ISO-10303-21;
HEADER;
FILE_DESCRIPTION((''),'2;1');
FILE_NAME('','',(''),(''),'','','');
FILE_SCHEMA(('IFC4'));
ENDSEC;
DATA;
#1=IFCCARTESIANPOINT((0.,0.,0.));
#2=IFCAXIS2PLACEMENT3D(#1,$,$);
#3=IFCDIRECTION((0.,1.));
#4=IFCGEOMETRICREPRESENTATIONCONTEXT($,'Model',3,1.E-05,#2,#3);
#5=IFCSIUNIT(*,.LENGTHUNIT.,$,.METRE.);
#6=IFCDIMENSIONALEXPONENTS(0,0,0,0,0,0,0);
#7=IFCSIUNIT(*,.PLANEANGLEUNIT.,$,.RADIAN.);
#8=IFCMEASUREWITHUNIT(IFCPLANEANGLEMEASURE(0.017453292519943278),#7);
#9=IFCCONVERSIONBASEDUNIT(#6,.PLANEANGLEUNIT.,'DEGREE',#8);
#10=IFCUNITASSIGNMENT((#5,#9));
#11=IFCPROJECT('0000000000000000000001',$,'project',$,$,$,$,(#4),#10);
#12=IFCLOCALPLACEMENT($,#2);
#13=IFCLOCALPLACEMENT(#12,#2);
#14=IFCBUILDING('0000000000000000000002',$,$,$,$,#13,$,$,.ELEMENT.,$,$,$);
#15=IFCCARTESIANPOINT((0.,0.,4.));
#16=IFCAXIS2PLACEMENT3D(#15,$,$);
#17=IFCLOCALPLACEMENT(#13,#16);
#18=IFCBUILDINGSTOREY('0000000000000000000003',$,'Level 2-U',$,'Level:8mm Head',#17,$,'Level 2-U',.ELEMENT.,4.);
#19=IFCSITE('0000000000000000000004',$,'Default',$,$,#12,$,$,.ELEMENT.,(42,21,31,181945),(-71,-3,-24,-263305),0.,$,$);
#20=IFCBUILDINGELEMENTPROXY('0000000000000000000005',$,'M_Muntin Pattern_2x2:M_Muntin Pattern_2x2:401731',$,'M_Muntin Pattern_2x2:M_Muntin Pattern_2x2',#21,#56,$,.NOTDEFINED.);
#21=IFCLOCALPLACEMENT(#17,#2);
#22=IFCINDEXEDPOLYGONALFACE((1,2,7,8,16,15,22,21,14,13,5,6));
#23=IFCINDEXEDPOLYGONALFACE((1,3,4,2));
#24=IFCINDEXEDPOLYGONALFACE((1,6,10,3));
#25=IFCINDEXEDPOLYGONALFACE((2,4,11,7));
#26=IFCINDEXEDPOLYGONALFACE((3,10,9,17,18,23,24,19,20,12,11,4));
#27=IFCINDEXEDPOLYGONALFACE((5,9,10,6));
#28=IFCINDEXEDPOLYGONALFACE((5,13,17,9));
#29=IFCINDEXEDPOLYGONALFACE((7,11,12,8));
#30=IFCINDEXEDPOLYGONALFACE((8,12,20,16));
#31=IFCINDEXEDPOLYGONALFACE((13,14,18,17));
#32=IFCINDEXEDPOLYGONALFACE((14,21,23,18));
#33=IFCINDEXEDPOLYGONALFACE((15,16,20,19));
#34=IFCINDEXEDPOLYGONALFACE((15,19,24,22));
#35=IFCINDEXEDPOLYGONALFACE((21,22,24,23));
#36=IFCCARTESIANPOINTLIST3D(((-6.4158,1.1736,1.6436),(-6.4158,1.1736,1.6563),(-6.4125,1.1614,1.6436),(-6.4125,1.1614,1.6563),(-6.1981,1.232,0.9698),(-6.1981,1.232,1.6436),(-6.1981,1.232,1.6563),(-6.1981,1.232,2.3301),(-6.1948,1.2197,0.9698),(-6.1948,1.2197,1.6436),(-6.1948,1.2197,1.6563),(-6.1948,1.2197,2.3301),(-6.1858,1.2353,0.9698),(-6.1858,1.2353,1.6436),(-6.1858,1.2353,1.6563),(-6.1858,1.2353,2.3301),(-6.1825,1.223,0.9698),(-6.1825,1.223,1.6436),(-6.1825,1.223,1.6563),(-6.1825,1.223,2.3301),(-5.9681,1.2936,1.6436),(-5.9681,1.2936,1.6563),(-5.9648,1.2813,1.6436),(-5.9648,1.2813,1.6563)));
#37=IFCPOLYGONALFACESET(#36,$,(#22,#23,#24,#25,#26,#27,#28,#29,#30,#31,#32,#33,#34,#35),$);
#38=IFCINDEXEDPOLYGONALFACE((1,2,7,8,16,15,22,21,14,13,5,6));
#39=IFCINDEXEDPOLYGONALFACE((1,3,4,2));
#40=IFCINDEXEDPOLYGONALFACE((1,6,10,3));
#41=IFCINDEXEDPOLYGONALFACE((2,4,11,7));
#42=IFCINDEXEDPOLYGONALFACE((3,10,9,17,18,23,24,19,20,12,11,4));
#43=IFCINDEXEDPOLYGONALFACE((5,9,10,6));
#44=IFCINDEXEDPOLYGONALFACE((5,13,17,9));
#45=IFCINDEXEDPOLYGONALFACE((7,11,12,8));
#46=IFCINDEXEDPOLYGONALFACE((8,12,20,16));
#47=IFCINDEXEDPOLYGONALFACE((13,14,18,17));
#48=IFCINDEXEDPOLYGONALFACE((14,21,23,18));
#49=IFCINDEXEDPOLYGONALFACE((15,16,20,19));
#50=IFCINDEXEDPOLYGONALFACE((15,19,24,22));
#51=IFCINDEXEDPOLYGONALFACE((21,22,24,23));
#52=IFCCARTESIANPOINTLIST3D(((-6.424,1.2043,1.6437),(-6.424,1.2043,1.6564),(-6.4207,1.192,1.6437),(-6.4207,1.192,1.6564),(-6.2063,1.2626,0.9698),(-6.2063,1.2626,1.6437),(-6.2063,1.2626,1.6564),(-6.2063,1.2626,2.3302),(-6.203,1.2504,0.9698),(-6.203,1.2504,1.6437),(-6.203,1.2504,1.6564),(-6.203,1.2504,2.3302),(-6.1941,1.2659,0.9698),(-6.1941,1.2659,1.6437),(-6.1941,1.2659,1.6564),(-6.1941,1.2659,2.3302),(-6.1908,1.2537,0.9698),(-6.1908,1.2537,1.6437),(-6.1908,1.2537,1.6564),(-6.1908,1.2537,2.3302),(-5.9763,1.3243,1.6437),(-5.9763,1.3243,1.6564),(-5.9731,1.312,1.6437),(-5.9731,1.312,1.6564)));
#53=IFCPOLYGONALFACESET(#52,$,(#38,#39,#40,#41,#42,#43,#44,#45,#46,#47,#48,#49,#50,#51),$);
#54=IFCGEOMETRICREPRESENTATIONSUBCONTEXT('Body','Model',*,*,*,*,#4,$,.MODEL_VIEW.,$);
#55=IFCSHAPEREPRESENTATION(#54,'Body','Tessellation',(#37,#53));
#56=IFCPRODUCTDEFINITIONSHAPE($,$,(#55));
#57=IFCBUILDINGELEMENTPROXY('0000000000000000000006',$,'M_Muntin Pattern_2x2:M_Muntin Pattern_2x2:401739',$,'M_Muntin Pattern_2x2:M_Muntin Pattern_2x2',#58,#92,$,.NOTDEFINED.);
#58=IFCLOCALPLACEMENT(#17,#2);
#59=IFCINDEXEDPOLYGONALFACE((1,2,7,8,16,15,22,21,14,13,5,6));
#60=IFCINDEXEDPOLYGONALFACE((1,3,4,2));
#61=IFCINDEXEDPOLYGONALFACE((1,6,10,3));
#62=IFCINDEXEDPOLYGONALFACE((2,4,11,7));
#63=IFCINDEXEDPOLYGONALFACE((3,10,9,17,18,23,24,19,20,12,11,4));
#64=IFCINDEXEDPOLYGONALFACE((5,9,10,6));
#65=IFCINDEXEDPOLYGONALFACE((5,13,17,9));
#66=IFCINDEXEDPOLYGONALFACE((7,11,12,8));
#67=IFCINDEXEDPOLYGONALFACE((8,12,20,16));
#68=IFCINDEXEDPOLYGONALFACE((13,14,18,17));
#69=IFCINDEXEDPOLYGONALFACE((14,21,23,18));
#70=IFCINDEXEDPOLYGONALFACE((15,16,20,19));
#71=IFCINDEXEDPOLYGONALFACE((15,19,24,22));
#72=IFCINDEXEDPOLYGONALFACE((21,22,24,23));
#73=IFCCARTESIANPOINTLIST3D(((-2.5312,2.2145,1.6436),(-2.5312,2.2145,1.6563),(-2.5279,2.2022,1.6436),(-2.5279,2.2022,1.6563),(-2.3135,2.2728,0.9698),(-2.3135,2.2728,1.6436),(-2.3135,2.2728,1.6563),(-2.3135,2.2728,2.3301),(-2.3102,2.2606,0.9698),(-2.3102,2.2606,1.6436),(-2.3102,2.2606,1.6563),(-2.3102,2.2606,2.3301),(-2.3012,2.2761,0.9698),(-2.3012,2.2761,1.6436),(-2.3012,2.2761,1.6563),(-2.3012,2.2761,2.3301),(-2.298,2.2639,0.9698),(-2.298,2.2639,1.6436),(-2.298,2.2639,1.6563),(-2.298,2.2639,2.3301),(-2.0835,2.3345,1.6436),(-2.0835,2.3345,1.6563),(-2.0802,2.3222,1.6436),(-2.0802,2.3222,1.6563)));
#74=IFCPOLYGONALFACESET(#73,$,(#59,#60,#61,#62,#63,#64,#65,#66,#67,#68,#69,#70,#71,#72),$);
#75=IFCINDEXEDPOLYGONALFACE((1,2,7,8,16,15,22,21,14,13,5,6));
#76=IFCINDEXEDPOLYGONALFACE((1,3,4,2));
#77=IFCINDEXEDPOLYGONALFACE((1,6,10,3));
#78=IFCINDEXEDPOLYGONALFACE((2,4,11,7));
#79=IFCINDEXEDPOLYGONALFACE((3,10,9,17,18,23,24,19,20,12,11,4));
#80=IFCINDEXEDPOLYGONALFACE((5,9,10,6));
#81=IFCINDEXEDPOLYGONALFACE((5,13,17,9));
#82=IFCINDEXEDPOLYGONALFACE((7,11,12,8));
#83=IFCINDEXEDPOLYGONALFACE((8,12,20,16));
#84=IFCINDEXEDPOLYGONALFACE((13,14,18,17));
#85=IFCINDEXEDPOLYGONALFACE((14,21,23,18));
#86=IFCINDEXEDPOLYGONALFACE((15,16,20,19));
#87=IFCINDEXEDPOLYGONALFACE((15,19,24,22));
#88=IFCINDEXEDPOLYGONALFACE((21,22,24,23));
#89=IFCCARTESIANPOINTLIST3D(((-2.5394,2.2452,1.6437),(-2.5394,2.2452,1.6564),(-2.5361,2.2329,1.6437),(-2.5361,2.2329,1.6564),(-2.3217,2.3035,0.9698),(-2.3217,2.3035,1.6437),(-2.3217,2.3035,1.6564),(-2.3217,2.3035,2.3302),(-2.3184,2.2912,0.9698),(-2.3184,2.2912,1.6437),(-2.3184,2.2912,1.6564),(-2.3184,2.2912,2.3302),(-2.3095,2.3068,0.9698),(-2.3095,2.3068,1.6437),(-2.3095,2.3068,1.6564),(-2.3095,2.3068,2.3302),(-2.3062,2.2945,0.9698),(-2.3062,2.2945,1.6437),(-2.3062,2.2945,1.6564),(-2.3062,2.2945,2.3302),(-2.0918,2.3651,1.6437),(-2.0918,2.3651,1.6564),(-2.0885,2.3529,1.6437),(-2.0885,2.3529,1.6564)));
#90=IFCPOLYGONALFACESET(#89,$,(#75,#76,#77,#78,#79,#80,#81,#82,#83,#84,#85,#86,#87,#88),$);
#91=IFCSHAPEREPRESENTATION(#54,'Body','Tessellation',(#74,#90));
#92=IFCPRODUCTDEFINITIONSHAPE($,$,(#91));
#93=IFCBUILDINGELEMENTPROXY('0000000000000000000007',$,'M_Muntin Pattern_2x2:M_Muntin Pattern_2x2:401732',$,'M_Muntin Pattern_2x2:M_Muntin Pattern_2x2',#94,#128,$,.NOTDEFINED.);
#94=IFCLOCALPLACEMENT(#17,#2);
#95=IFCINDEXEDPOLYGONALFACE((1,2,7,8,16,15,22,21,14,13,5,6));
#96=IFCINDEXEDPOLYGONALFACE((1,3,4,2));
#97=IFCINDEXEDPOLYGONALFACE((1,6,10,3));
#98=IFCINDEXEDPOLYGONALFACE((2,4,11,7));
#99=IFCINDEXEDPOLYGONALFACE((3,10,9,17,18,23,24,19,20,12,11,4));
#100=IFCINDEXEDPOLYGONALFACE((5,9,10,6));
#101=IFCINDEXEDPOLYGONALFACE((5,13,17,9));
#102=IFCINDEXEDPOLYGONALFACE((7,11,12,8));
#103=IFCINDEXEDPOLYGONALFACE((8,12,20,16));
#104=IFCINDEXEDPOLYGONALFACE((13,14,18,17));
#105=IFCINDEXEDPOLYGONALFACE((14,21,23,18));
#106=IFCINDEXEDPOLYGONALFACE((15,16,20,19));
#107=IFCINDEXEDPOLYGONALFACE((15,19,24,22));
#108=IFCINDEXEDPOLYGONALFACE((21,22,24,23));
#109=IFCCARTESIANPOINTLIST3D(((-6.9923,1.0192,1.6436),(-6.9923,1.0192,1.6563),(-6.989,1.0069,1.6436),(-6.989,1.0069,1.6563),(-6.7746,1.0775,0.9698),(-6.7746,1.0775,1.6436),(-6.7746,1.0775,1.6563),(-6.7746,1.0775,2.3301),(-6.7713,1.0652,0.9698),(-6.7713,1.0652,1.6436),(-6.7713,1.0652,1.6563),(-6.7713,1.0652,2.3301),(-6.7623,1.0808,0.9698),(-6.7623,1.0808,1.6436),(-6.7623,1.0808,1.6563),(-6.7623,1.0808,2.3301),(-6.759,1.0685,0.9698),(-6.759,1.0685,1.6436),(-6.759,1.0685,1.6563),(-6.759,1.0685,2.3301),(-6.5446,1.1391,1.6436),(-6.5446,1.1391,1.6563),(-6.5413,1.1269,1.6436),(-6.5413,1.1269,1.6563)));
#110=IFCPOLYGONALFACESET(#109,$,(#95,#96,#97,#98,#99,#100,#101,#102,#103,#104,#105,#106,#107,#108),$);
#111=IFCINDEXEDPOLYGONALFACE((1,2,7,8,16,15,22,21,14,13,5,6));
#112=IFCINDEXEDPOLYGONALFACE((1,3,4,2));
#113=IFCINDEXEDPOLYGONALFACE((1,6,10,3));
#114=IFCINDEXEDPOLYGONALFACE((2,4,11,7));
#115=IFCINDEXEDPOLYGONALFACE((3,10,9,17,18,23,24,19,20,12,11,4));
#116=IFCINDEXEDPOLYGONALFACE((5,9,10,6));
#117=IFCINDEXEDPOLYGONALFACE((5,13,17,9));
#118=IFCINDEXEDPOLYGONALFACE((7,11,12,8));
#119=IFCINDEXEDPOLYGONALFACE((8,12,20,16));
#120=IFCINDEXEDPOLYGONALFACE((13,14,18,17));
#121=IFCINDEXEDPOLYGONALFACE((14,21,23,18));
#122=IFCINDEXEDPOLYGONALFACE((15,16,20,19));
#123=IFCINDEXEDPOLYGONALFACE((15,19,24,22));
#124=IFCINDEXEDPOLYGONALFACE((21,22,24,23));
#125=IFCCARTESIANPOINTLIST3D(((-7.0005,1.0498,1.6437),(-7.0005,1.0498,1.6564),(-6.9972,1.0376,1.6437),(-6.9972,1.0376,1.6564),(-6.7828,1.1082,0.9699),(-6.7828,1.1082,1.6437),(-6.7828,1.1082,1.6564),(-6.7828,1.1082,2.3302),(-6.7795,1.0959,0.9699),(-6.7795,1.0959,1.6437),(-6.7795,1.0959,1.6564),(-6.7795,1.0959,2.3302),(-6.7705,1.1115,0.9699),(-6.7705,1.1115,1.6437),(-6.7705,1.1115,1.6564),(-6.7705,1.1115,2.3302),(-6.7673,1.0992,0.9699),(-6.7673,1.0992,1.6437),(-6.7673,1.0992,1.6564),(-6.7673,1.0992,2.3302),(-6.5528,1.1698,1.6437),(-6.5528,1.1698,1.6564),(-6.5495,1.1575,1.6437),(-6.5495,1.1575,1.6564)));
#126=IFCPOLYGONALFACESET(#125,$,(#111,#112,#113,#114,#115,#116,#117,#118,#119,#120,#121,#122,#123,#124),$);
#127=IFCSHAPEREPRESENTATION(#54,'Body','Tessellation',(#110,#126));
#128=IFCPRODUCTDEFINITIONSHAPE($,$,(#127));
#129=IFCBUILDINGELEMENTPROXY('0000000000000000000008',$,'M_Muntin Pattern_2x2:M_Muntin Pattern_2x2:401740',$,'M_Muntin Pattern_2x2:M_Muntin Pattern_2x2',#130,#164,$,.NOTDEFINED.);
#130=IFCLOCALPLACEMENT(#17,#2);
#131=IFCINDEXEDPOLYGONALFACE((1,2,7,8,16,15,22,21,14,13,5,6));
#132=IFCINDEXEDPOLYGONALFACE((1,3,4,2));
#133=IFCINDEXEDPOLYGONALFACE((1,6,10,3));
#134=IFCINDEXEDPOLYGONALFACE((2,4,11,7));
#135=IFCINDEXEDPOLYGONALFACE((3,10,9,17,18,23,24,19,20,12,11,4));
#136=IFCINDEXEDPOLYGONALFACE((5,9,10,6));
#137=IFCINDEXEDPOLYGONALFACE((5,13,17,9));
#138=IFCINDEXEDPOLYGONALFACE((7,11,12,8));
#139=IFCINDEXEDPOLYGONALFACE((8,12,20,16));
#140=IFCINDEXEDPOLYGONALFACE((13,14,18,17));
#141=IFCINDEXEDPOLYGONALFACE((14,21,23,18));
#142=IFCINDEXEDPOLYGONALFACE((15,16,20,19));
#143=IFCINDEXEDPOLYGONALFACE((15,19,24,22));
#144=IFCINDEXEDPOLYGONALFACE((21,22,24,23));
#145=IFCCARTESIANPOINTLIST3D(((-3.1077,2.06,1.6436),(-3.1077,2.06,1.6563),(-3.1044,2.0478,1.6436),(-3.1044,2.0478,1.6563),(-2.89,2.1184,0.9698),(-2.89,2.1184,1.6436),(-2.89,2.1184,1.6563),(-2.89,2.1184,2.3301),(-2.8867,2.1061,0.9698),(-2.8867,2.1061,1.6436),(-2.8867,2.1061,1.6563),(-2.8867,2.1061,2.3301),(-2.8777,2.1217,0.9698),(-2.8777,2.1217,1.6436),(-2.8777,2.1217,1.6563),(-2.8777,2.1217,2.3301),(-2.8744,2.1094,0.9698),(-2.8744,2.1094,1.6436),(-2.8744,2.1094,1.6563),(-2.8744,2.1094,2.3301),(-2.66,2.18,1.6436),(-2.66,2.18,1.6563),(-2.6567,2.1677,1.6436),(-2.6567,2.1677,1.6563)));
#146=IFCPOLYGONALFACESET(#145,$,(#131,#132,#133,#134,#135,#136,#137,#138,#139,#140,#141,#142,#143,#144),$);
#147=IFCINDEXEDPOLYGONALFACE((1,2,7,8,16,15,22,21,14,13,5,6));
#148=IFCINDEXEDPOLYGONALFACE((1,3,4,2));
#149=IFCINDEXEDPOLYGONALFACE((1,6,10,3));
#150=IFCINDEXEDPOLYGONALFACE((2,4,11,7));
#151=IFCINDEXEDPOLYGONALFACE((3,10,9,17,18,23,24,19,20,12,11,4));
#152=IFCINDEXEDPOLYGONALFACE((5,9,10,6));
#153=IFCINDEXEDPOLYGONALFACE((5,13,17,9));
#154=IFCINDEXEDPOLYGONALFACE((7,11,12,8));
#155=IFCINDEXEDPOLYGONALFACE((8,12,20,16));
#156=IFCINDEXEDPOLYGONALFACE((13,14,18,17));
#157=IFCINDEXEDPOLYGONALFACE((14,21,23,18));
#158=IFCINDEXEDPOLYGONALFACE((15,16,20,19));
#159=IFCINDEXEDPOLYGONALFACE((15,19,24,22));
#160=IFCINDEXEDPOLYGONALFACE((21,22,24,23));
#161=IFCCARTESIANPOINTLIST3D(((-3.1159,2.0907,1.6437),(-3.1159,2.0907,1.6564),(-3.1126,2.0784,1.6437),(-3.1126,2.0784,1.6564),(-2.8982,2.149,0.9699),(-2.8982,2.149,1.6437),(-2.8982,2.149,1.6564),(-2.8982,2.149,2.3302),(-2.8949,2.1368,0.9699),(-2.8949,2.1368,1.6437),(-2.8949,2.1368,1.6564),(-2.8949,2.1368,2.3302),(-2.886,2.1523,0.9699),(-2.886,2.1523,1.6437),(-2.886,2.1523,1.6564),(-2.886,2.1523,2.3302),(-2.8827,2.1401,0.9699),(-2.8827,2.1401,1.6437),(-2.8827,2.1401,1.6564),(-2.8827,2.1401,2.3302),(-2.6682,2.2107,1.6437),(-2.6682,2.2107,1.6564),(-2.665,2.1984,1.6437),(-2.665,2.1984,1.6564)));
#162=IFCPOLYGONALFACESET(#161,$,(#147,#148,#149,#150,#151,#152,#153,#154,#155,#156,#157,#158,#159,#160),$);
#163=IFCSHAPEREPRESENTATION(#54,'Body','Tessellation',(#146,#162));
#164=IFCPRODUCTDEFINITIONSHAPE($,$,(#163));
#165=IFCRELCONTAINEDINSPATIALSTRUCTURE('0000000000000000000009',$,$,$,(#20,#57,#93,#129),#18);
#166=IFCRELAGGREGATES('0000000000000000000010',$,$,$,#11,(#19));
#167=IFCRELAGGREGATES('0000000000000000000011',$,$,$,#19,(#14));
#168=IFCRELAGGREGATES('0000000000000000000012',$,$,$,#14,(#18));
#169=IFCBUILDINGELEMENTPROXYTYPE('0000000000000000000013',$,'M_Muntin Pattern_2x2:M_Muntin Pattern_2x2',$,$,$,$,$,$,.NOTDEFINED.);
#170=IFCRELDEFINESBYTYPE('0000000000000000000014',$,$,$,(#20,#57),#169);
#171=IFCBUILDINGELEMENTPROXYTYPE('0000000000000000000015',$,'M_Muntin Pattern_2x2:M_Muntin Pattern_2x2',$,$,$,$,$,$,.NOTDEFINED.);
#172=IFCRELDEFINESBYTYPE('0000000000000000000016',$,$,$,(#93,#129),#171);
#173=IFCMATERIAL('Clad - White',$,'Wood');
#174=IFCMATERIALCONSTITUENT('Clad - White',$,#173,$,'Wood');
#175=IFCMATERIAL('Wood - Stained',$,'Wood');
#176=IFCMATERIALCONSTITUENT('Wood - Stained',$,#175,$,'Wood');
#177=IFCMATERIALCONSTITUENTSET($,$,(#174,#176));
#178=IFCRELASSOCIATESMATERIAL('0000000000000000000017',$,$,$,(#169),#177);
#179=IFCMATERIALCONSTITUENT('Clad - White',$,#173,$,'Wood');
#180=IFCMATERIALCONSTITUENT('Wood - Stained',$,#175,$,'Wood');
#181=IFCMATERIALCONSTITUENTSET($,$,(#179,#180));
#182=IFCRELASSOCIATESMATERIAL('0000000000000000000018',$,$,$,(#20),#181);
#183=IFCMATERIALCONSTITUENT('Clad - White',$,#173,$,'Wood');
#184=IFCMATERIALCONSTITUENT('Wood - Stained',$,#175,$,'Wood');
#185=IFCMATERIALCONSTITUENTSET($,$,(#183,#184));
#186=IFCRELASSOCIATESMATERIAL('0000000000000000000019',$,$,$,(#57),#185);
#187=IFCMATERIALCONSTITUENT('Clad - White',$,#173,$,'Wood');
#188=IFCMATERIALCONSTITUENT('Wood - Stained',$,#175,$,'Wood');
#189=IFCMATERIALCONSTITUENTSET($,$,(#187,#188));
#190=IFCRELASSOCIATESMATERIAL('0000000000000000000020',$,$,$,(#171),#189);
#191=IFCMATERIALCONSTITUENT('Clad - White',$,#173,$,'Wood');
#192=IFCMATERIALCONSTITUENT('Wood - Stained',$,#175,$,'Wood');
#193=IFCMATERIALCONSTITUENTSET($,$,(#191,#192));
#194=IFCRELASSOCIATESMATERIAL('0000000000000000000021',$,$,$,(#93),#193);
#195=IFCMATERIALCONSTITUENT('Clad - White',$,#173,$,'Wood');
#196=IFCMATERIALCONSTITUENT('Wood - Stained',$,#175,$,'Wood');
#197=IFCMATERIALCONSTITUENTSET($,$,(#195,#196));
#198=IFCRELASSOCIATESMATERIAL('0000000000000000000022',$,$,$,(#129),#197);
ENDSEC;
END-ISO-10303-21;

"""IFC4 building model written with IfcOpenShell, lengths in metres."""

from ifc_helpers import new_model, entity, si_unit, converted_unit, direction, frame, origin, place, context, subcontext, project, spatial, indexed_curve, outline, extrude, source, transform, mapped, material, constituent, constituent_set, type_object, type_shapes, element, save


model = new_model("IFC4")

# Units and contexts
model_context = context("Model", 3, precision=1e-05, world=origin(), true_north=direction((0.0, 1.0)))
body_context = subcontext(model_context, "Body", "Model", "MODEL_VIEW")
ifc_project = project(units=[si_unit("LENGTHUNIT", "METRE"), converted_unit("PLANEANGLEUNIT", "DEGREE", entity("IfcPlaneAngleMeasure", 0.017453292519943278), si_unit("PLANEANGLEUNIT", "RADIAN"), dimensions=[0, 0, 0, 0, 0, 0, 0])], contexts=[model_context])

# Site, building, storey
site_placement = place(None, origin())
site = spatial("IfcSite", under=ifc_project, at=site_placement, Name="Default", CompositionType="ELEMENT", RefLatitude=(42, 21, 31, 181945), RefLongitude=(-71, -3, -24, -263305), RefElevation=0.0)
building_placement = place(site_placement, origin())
building = spatial("IfcBuilding", under=site, at=building_placement, CompositionType="ELEMENT")
storey_placement = place(building_placement, frame((0.0, 0.0, 4.0)))
storey = spatial("IfcBuildingStorey", under=building, at=storey_placement, Name="Level 2-U", ObjectType="Level:8mm Head", LongName="Level 2-U", CompositionType="ELEMENT", Elevation=4.0)

# Building element proxies
ifc_material_1 = material(Name="Clad - White", Category="Wood")
ifc_constituent_1 = constituent(ifc_material_1, Name="Clad - White", Category="Wood")
ifc_material_2 = material(Name="Wood - Stained", Category="Wood")
ifc_constituent_2 = constituent(ifc_material_2, Name="Wood - Stained", Category="Wood")
ifc_constituent_set_1 = constituent_set(constituents=[ifc_constituent_1, ifc_constituent_2])
ifc_constituent_3 = constituent(ifc_material_1, Name="Clad - White", Category="Wood")
ifc_constituent_4 = constituent(ifc_material_2, Name="Wood - Stained", Category="Wood")
ifc_constituent_set_2 = constituent_set(constituents=[ifc_constituent_3, ifc_constituent_4])
building_element_proxy_type_1 = type_object("IfcBuildingElementProxyType", Name="M_Muntin Pattern_2x2:M_Muntin Pattern_2x2", PredefinedType="NOTDEFINED", material=ifc_constituent_set_2)
shared_shape_1 = source(origin(), body_context, "Body", "SweptSolid", [
    extrude(outline(indexed_curve([(0.0064, -0.0064), (0.6801, -0.0064), (0.6801, 0.0063), (0.0064, 0.0063), (0.0064, 0.2317), (-0.0063, 0.2317), (-0.0063, 0.0063), (-0.6802, 0.0063), (-0.6802, -0.0064), (-0.0063, -0.0064), (-0.0063, -0.2317), (0.0064, -0.2317), (0.0064, -0.0064)], self_intersect=False)), frame((0.0, 0.0095, 0.6801), z_axis=(0.0, 1.0, 0.0), x_axis=(0.0, 0.0, 1.0)), (0.0, 0.0, 1.0), 0.0127),
    extrude(outline(indexed_curve([(0.0064, -0.0064), (0.6802, -0.0064), (0.6802, 0.0063), (0.0064, 0.0063), (0.0064, 0.2317), (-0.0063, 0.2317), (-0.0063, 0.0063), (-0.6802, 0.0063), (-0.6802, -0.0064), (-0.0063, -0.0064), (-0.0063, -0.2317), (0.0064, -0.2317), (0.0064, -0.0064)], self_intersect=False)), frame((0.0, -0.0222, 0.6802), z_axis=(0.0, 1.0, 0.0), x_axis=(0.0, 0.0, 1.0)), (0.0, 0.0, 1.0), 0.0127),
])
type_shapes(building_element_proxy_type_1, [shared_shape_1])
proxy_1_placement = place(storey_placement, frame((-6.1944, 1.2428, 0.9698), z_axis=(0.0, 0.0, 1.0), x_axis=(-0.965926, -0.258819, 0.0)))
element("IfcBuildingElementProxy", 1, at=proxy_1_placement, inside=storey, type_object=building_element_proxy_type_1, material=ifc_constituent_set_1, Name="M_Muntin Pattern_2x2:M_Muntin Pattern_2x2:401731", ObjectType="M_Muntin Pattern_2x2:M_Muntin Pattern_2x2", PredefinedType="NOTDEFINED", context=body_context, shape_type="MappedRepresentation", body=[
    mapped(shared_shape_1, transform((0.0, 0.0, 0.0), scale=1.0)),
])
ifc_constituent_5 = constituent(ifc_material_1, Name="Clad - White", Category="Wood")
ifc_constituent_6 = constituent(ifc_material_2, Name="Wood - Stained", Category="Wood")
ifc_constituent_set_3 = constituent_set(constituents=[ifc_constituent_5, ifc_constituent_6])
proxy_2_placement = place(storey_placement, frame((-2.3098, 2.2837, 0.9698), z_axis=(0.0, 0.0, 1.0), x_axis=(-0.965926, -0.258819, 0.0)))
element("IfcBuildingElementProxy", 2, at=proxy_2_placement, inside=storey, type_object=building_element_proxy_type_1, material=ifc_constituent_set_3, Name="M_Muntin Pattern_2x2:M_Muntin Pattern_2x2:401739", ObjectType="M_Muntin Pattern_2x2:M_Muntin Pattern_2x2", PredefinedType="NOTDEFINED", context=body_context, shape_type="MappedRepresentation", body=[
    mapped(shared_shape_1, transform((0.0, 0.0, 0.0), scale=1.0)),
])
ifc_constituent_7 = constituent(ifc_material_1, Name="Clad - White", Category="Wood")
ifc_constituent_8 = constituent(ifc_material_2, Name="Wood - Stained", Category="Wood")
ifc_constituent_set_4 = constituent_set(constituents=[ifc_constituent_7, ifc_constituent_8])
ifc_constituent_9 = constituent(ifc_material_1, Name="Clad - White", Category="Wood")
ifc_constituent_10 = constituent(ifc_material_2, Name="Wood - Stained", Category="Wood")
ifc_constituent_set_5 = constituent_set(constituents=[ifc_constituent_9, ifc_constituent_10])
building_element_proxy_type_2 = type_object("IfcBuildingElementProxyType", Name="M_Muntin Pattern_2x2:M_Muntin Pattern_2x2", PredefinedType="NOTDEFINED", material=ifc_constituent_set_5)
shared_shape_2 = source(origin(), body_context, "Body", "SweptSolid", [
    extrude(outline(indexed_curve([(0.0064, -0.0064), (0.6801, -0.0064), (0.6801, 0.0063), (0.0064, 0.0063), (0.0064, 0.2317), (-0.0063, 0.2317), (-0.0063, 0.0063), (-0.6802, 0.0063), (-0.6802, -0.0064), (-0.0063, -0.0064), (-0.0063, -0.2317), (0.0064, -0.2317), (0.0064, -0.0064)], self_intersect=False)), frame((0.0, -0.0222, 0.6801), z_axis=(0.0, 1.0, 0.0), x_axis=(0.0, 0.0, 1.0)), (0.0, 0.0, 1.0), 0.0127),
    extrude(outline(indexed_curve([(0.0064, -0.0064), (0.6802, -0.0064), (0.6802, 0.0063), (0.0064, 0.0063), (0.0064, 0.2317), (-0.0063, 0.2317), (-0.0063, 0.0063), (-0.6802, 0.0063), (-0.6802, -0.0064), (-0.0063, -0.0064), (-0.0063, -0.2317), (0.0064, -0.2317), (0.0064, -0.0064)], self_intersect=False)), frame((0.0, 0.0095, 0.6802), z_axis=(0.0, 1.0, 0.0), x_axis=(0.0, 0.0, 1.0)), (0.0, 0.0, 1.0), 0.0127),
])
type_shapes(building_element_proxy_type_2, [shared_shape_2])
proxy_3_placement = place(storey_placement, frame((-6.7709, 1.0884, 0.9699), z_axis=(0.0, 0.0, 1.0), x_axis=(0.965926, 0.258819, 0.0)))
element("IfcBuildingElementProxy", 3, at=proxy_3_placement, inside=storey, type_object=building_element_proxy_type_2, material=ifc_constituent_set_4, Name="M_Muntin Pattern_2x2:M_Muntin Pattern_2x2:401732", ObjectType="M_Muntin Pattern_2x2:M_Muntin Pattern_2x2", PredefinedType="NOTDEFINED", context=body_context, shape_type="MappedRepresentation", body=[
    mapped(shared_shape_2, transform((0.0, 0.0, 0.0), scale=1.0)),
])
ifc_constituent_11 = constituent(ifc_material_1, Name="Clad - White", Category="Wood")
ifc_constituent_12 = constituent(ifc_material_2, Name="Wood - Stained", Category="Wood")
ifc_constituent_set_6 = constituent_set(constituents=[ifc_constituent_11, ifc_constituent_12])
proxy_4_placement = place(storey_placement, frame((-2.8863, 2.1292, 0.9699), z_axis=(0.0, 0.0, 1.0), x_axis=(0.965926, 0.258819, 0.0)))
element("IfcBuildingElementProxy", 4, at=proxy_4_placement, inside=storey, type_object=building_element_proxy_type_2, material=ifc_constituent_set_6, Name="M_Muntin Pattern_2x2:M_Muntin Pattern_2x2:401740", ObjectType="M_Muntin Pattern_2x2:M_Muntin Pattern_2x2", PredefinedType="NOTDEFINED", context=body_context, shape_type="MappedRepresentation", body=[
    mapped(shared_shape_2, transform((0.0, 0.0, 0.0), scale=1.0)),
])

save(model, "model.ifc")
